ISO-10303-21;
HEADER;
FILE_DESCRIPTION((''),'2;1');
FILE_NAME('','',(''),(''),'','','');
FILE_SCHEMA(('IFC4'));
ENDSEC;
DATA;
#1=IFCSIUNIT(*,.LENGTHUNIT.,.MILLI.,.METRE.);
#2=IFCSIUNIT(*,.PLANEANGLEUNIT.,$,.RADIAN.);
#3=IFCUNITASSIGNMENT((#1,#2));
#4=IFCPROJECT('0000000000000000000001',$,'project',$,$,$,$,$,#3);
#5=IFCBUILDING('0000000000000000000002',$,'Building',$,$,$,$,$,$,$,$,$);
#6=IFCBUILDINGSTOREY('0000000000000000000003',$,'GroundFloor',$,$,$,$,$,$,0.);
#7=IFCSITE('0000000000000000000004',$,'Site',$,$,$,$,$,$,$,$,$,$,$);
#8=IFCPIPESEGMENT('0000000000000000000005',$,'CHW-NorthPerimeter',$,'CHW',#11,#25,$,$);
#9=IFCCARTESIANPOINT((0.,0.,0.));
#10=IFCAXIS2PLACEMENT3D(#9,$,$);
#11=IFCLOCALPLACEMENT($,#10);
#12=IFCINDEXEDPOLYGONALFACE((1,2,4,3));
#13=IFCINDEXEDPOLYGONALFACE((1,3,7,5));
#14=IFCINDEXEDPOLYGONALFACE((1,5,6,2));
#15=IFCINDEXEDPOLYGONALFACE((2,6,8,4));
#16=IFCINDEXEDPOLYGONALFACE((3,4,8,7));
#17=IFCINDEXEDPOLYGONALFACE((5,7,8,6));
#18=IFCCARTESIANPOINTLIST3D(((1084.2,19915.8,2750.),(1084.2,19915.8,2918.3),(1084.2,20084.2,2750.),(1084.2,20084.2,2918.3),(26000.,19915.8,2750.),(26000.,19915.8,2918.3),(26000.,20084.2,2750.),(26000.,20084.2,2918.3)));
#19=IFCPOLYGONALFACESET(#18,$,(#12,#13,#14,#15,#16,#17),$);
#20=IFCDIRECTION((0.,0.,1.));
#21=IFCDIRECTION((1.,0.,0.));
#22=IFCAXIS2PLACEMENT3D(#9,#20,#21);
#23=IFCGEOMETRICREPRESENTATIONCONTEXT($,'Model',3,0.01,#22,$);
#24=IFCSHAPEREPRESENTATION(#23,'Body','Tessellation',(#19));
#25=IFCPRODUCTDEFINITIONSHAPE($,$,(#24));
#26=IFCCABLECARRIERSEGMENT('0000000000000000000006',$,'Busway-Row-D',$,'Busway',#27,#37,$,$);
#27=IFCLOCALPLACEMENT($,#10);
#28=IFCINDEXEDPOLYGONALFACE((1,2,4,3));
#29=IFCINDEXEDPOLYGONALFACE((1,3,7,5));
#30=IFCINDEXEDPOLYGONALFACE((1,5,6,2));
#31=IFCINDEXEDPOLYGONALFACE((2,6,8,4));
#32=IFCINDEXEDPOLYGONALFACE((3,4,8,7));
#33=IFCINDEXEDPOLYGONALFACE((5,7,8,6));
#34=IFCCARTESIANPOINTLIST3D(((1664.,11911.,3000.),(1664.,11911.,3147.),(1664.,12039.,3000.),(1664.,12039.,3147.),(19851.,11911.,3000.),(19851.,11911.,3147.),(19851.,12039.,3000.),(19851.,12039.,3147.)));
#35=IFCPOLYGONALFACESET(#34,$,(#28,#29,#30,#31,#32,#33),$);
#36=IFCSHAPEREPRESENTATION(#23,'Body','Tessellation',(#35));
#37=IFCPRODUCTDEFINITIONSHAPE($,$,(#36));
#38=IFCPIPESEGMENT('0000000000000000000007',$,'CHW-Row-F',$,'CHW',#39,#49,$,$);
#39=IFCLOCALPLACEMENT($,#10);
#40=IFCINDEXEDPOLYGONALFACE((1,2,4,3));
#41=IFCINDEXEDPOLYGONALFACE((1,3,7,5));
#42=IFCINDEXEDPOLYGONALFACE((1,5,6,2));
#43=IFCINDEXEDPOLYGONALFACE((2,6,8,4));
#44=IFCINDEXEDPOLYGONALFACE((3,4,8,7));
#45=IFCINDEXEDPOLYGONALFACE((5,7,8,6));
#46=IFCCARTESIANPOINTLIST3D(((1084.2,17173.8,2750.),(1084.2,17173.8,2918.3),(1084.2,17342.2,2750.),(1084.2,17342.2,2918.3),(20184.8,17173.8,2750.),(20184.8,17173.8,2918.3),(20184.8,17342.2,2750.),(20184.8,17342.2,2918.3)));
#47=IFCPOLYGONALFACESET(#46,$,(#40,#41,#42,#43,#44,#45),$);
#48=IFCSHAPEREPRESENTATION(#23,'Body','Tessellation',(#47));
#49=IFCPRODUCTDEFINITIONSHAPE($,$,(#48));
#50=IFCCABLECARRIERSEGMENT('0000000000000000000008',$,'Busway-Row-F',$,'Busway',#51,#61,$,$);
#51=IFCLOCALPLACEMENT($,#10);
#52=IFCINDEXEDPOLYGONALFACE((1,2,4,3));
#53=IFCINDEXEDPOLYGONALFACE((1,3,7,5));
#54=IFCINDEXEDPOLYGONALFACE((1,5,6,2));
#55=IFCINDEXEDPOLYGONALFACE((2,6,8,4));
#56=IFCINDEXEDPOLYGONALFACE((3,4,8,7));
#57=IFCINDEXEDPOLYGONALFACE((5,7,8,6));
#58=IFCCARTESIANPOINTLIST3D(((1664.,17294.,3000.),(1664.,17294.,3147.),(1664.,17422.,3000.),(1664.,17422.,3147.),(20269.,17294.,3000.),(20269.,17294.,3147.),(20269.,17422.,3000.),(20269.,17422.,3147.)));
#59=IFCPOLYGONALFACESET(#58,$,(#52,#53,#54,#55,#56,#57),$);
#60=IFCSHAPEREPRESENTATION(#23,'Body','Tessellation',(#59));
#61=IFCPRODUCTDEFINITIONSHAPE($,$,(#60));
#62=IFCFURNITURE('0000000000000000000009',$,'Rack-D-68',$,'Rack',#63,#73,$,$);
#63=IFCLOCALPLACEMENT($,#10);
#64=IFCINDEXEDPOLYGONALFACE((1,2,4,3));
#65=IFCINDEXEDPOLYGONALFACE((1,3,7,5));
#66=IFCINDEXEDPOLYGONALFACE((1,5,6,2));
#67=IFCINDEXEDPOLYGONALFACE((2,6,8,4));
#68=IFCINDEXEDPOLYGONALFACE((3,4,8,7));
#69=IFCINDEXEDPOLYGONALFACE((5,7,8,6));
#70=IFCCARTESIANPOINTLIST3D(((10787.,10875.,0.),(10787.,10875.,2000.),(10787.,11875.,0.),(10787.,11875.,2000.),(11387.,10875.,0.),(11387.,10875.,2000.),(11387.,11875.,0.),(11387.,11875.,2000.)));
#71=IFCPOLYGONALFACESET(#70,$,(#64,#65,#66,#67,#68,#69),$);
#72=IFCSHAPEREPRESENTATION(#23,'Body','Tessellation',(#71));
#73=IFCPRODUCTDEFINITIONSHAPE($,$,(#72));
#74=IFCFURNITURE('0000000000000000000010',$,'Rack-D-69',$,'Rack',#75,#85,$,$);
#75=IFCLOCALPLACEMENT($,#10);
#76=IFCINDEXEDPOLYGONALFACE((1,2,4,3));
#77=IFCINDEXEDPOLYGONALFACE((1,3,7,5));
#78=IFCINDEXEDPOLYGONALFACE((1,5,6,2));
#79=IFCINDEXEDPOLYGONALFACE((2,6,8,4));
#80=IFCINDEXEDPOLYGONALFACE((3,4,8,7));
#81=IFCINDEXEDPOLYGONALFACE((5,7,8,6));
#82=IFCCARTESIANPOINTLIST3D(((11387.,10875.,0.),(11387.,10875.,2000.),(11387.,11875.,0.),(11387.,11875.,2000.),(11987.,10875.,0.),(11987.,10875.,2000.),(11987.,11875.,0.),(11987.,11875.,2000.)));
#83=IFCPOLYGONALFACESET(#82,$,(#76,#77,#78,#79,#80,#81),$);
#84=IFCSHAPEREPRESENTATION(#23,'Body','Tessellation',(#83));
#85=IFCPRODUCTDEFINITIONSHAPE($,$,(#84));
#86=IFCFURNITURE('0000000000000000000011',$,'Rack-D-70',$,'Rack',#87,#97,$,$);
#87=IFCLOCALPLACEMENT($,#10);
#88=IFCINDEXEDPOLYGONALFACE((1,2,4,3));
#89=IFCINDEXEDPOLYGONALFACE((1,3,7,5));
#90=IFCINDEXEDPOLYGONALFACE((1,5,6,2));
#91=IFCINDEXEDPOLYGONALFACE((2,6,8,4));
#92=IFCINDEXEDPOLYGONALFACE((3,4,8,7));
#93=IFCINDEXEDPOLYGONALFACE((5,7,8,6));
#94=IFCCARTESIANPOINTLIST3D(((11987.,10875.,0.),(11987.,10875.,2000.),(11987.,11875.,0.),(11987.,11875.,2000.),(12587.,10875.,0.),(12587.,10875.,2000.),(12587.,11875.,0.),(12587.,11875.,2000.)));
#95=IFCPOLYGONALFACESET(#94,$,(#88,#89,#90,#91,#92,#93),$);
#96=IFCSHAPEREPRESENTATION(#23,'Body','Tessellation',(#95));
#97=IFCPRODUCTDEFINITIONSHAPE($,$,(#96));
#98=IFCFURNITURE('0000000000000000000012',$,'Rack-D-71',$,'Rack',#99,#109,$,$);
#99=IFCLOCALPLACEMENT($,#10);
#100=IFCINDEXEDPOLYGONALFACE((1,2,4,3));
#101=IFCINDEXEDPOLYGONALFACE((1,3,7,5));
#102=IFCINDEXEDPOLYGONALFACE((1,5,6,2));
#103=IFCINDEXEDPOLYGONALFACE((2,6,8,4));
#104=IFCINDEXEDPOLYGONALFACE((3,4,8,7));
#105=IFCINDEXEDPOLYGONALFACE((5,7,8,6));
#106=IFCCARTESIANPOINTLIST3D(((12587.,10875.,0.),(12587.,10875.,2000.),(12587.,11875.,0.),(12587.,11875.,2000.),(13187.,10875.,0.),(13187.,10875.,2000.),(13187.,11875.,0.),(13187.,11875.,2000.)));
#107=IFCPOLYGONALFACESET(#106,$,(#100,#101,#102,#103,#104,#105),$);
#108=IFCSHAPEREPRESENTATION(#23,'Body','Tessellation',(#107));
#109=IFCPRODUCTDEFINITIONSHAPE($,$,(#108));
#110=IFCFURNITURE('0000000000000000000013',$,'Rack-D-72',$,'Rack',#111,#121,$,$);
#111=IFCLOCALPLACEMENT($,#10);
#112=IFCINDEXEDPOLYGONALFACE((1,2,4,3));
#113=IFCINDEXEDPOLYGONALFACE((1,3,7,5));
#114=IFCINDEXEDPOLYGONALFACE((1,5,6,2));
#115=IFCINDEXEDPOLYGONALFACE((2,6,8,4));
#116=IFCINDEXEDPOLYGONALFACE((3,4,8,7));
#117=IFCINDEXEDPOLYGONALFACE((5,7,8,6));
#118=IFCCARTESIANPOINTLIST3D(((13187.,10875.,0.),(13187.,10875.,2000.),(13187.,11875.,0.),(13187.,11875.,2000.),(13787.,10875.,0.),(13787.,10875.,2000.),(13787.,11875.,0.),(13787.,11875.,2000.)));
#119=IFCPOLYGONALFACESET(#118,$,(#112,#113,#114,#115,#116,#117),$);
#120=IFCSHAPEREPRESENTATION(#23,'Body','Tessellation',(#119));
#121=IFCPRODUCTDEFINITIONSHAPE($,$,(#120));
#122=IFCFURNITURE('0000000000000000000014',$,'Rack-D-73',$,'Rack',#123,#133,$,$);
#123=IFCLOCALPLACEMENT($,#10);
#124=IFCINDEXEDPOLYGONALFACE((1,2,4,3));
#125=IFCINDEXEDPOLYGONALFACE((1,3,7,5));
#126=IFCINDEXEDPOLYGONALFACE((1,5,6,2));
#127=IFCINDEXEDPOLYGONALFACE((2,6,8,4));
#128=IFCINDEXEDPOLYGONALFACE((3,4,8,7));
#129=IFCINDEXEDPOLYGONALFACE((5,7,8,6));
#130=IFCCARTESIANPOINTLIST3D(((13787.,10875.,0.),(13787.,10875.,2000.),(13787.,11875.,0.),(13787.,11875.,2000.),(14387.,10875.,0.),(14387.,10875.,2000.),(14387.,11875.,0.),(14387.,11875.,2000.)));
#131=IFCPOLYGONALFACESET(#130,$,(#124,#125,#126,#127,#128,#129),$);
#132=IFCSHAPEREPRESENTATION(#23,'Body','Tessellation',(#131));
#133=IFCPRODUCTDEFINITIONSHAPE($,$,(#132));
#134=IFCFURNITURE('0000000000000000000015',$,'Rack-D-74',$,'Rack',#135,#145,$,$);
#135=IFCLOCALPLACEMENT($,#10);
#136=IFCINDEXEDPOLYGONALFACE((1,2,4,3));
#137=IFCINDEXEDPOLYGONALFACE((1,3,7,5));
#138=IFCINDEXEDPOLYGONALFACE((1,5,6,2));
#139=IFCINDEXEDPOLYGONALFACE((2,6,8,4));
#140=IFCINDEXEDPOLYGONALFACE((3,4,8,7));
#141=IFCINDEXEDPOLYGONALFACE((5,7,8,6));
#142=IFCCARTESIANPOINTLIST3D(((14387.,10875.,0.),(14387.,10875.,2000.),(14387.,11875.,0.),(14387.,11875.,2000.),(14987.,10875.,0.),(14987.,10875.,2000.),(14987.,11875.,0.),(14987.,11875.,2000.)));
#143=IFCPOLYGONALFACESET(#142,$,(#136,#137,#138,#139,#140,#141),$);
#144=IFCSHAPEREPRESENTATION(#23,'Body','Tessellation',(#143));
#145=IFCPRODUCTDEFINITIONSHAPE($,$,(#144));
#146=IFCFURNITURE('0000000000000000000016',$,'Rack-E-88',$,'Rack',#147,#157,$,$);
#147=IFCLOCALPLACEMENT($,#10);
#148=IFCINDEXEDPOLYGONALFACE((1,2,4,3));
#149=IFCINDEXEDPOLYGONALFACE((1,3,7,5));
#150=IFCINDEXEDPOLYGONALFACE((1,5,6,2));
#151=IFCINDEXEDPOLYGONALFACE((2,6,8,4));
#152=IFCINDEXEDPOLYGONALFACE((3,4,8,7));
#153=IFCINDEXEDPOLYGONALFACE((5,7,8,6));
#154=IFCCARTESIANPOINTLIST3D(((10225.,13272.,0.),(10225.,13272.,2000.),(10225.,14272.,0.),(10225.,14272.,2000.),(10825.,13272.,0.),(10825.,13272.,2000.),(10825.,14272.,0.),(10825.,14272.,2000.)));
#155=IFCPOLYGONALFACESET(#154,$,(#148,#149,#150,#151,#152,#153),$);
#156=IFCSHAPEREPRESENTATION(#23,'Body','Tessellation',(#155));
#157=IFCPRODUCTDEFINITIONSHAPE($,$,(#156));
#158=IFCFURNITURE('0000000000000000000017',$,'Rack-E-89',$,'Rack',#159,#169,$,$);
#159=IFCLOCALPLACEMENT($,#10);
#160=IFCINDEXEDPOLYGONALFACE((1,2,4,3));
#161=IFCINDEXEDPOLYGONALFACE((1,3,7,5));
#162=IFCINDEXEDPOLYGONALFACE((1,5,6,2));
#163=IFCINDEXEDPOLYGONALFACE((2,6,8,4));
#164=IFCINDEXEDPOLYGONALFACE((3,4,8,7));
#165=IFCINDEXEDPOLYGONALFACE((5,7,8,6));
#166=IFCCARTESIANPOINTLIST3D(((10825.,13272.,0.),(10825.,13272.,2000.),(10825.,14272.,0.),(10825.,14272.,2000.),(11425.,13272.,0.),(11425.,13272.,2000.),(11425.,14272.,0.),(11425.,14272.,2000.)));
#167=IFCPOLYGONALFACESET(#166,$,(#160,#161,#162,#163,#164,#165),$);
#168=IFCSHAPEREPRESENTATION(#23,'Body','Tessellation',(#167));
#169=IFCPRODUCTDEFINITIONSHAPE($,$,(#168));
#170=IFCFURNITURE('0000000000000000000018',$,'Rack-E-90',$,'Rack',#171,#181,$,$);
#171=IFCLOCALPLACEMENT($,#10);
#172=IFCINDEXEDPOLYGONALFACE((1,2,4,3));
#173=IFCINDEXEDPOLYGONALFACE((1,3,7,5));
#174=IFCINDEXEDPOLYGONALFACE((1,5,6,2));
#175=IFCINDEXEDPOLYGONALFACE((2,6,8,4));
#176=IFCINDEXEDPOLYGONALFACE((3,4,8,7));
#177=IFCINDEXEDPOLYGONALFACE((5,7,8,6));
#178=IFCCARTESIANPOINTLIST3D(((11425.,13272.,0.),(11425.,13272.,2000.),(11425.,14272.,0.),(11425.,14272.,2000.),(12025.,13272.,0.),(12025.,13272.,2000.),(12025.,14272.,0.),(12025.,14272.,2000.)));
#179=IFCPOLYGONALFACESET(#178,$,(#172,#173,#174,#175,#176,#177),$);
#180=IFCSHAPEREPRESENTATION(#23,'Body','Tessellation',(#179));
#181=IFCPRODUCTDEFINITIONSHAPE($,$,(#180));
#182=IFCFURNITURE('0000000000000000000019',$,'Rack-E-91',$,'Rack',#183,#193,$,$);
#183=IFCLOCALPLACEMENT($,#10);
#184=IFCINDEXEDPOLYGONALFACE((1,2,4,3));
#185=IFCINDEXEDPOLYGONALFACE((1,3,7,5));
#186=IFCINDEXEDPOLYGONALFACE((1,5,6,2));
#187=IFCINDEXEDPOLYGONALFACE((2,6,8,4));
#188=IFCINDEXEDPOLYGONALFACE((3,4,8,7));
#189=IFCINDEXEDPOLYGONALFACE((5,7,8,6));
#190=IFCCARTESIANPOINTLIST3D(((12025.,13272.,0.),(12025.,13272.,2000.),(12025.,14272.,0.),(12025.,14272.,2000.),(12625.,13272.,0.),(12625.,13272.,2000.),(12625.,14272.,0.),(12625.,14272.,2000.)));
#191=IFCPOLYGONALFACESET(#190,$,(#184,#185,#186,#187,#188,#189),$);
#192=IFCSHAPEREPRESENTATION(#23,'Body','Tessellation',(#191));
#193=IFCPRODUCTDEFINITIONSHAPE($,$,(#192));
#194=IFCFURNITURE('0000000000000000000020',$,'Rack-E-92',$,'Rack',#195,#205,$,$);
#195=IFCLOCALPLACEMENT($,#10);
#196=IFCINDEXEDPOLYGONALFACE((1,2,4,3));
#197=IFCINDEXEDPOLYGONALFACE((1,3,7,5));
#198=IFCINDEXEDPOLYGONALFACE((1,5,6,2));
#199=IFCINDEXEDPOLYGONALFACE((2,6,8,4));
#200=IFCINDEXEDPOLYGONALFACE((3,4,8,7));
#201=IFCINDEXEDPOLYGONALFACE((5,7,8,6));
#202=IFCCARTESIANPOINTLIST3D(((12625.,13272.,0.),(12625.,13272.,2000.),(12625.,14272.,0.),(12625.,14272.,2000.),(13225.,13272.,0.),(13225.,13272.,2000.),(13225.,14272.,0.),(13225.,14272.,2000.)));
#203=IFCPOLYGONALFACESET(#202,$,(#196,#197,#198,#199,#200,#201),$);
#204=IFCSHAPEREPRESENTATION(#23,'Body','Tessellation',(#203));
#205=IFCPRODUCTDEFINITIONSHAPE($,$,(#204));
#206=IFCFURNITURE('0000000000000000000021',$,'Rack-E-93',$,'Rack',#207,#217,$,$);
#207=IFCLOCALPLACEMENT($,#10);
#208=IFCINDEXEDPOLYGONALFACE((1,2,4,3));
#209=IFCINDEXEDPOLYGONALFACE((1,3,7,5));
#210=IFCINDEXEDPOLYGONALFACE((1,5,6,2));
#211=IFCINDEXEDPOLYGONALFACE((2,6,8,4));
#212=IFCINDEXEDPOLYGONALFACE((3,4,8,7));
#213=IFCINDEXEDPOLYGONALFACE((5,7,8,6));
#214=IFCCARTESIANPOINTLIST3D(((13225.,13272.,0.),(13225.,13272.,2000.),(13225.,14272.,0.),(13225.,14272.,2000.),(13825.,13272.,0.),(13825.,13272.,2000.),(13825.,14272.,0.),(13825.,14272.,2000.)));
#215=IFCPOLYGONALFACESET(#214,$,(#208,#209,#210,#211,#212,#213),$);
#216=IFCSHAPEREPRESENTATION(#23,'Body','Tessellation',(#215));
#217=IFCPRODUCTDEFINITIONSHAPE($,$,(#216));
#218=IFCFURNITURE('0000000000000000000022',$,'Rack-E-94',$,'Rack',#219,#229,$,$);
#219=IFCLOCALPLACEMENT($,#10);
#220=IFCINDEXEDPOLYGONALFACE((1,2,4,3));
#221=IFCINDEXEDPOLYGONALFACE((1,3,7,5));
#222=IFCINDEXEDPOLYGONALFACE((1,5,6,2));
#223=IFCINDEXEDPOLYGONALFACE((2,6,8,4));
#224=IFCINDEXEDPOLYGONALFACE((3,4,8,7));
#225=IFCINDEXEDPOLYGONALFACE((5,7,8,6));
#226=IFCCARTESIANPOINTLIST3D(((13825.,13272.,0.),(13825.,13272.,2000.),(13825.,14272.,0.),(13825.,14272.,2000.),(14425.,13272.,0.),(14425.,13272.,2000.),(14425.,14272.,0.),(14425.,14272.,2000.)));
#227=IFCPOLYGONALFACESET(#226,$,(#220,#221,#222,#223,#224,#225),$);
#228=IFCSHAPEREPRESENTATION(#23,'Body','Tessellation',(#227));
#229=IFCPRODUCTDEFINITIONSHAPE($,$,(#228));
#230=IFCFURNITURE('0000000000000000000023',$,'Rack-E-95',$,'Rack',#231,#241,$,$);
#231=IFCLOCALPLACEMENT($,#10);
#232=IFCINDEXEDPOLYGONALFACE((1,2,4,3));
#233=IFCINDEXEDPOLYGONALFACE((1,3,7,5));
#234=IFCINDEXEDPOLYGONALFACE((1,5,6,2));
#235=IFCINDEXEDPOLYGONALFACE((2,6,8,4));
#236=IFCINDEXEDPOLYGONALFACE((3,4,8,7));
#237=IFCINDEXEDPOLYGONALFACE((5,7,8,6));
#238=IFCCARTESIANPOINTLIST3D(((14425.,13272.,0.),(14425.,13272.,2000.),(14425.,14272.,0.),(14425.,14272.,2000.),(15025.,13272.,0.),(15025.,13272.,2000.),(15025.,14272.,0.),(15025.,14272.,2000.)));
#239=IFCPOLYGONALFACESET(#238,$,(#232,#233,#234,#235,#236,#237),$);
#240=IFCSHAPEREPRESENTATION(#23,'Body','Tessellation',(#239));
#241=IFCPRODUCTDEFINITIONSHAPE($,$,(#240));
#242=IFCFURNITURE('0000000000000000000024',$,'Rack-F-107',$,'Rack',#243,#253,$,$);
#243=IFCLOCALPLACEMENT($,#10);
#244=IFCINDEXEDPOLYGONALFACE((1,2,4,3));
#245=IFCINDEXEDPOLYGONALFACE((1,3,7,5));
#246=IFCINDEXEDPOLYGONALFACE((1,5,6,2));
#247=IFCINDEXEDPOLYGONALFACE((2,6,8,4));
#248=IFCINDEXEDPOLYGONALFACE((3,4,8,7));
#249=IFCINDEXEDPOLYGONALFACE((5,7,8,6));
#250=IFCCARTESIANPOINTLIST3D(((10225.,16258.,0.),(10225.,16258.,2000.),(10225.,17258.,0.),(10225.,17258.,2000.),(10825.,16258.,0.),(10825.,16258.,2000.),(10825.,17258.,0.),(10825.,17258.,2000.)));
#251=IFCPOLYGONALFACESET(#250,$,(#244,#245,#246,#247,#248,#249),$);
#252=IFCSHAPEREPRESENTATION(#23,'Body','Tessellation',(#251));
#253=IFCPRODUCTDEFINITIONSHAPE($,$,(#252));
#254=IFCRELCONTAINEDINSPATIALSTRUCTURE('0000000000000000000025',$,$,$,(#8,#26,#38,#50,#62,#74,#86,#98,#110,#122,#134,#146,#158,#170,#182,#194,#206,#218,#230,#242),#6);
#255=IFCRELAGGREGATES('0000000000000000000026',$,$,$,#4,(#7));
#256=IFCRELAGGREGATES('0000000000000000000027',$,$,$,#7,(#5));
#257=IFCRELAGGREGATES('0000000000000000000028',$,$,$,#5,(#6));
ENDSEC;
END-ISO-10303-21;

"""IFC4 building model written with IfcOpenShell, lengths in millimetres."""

from ifc_helpers import new_model, si_unit, frame, origin, origin_with_axes, origin_2d, place, context, project, spatial, rectangle, extrude, element, save


model = new_model("IFC4")

# Units and contexts
model_context = context("Model", 3, precision=0.01, world=origin_with_axes())
ifc_project = project(units=[si_unit("LENGTHUNIT", "METRE", prefix="MILLI"), si_unit("PLANEANGLEUNIT", "RADIAN")])

# Site, building, storey
site = spatial("IfcSite", under=ifc_project, Name="Site")
building = spatial("IfcBuilding", under=site, Name="Building")
storey = spatial("IfcBuildingStorey", under=building, Name="GroundFloor", Elevation=0.0)

# Pipe segment
pipe_segment_1_placement = place(None, frame((13542.1, 20000.0, 2750.0), z_axis=(0.0, 0.0, 1.0), x_axis=(1.0, 0.0, 0.0)))
element("IfcPipeSegment", 1, at=pipe_segment_1_placement, inside=storey, Name="CHW-NorthPerimeter", ObjectType="CHW", context=model_context, shape_type="SweptSolid", body=[
    extrude(rectangle(XDim=24915.8, YDim=168.3, at=origin_2d()), origin(), (0.0, 0.0, 1.0), 168.3),
])

# Cable carrier segment
cable_carrier_segment_1_placement = place(None, frame((10757.5, 11975.0, 3000.0), z_axis=(0.0, 0.0, 1.0), x_axis=(1.0, 0.0, 0.0)))
element("IfcCableCarrierSegment", 2, at=cable_carrier_segment_1_placement, inside=storey, Name="Busway-Row-D", ObjectType="Busway", context=model_context, shape_type="SweptSolid", body=[
    extrude(rectangle(XDim=18187.0, YDim=128.0, at=origin_2d()), origin(), (0.0, 0.0, 1.0), 147.0),
])

# Pipe segment
pipe_segment_2_placement = place(None, frame((10634.5, 17258.0, 2750.0), z_axis=(0.0, 0.0, 1.0), x_axis=(1.0, 0.0, 0.0)))
element("IfcPipeSegment", 3, at=pipe_segment_2_placement, inside=storey, Name="CHW-Row-F", ObjectType="CHW", context=model_context, shape_type="SweptSolid", body=[
    extrude(rectangle(XDim=19100.7, YDim=168.3, at=origin_2d()), origin(), (0.0, 0.0, 1.0), 168.3),
])

# Cable carrier segment
cable_carrier_segment_2_placement = place(None, frame((10966.5, 17358.0, 3000.0), z_axis=(0.0, 0.0, 1.0), x_axis=(1.0, 0.0, 0.0)))
element("IfcCableCarrierSegment", 4, at=cable_carrier_segment_2_placement, inside=storey, Name="Busway-Row-F", ObjectType="Busway", context=model_context, shape_type="SweptSolid", body=[
    extrude(rectangle(XDim=18605.0, YDim=128.0, at=origin_2d()), origin(), (0.0, 0.0, 1.0), 147.0),
])

# Furniture
for number, where, z_axis, x_axis, name in (
    (5, (11087.0, 11375.0, 0.0), (0.0, 0.0, 1.0), (1.0, 0.0, 0.0), "Rack-D-68"),
    (6, (11687.0, 11375.0, 0.0), (0.0, 0.0, 1.0), (1.0, 0.0, 0.0), "Rack-D-69"),
    (7, (12287.0, 11375.0, 0.0), (0.0, 0.0, 1.0), (1.0, 0.0, 0.0), "Rack-D-70"),
    (8, (12887.0, 11375.0, 0.0), (0.0, 0.0, 1.0), (1.0, 0.0, 0.0), "Rack-D-71"),
    (9, (13487.0, 11375.0, 0.0), (0.0, 0.0, 1.0), (1.0, 0.0, 0.0), "Rack-D-72"),
    (10, (14087.0, 11375.0, 0.0), (0.0, 0.0, 1.0), (1.0, 0.0, 0.0), "Rack-D-73"),
    (11, (14687.0, 11375.0, 0.0), (0.0, 0.0, 1.0), (1.0, 0.0, 0.0), "Rack-D-74"),
    (12, (10525.0, 13772.0, 0.0), (0.0, 0.0, 1.0), (1.0, 0.0, 0.0), "Rack-E-88"),
    (13, (11125.0, 13772.0, 0.0), (0.0, 0.0, 1.0), (1.0, 0.0, 0.0), "Rack-E-89"),
    (14, (11725.0, 13772.0, 0.0), (0.0, 0.0, 1.0), (1.0, 0.0, 0.0), "Rack-E-90"),
    (15, (12325.0, 13772.0, 0.0), (0.0, 0.0, 1.0), (1.0, 0.0, 0.0), "Rack-E-91"),
    (16, (12925.0, 13772.0, 0.0), (0.0, 0.0, 1.0), (1.0, 0.0, 0.0), "Rack-E-92"),
    (17, (13525.0, 13772.0, 0.0), (0.0, 0.0, 1.0), (1.0, 0.0, 0.0), "Rack-E-93"),
    (18, (14125.0, 13772.0, 0.0), (0.0, 0.0, 1.0), (1.0, 0.0, 0.0), "Rack-E-94"),
    (19, (14725.0, 13772.0, 0.0), (0.0, 0.0, 1.0), (1.0, 0.0, 0.0), "Rack-E-95"),
    (20, (10525.0, 16758.0, 0.0), (0.0, 0.0, 1.0), (1.0, 0.0, 0.0), "Rack-F-107"),
):
    element("IfcFurniture", number, at=place(None, frame(where, z_axis=z_axis, x_axis=x_axis)), inside=storey, Name=name, ObjectType="Rack", context=model_context, shape_type="SweptSolid", body=[
        extrude(rectangle(XDim=600.0, YDim=1000.0, at=origin_2d()), origin(), (0.0, 0.0, 1.0), 2000.0),
    ])

save(model, "model.ifc")
